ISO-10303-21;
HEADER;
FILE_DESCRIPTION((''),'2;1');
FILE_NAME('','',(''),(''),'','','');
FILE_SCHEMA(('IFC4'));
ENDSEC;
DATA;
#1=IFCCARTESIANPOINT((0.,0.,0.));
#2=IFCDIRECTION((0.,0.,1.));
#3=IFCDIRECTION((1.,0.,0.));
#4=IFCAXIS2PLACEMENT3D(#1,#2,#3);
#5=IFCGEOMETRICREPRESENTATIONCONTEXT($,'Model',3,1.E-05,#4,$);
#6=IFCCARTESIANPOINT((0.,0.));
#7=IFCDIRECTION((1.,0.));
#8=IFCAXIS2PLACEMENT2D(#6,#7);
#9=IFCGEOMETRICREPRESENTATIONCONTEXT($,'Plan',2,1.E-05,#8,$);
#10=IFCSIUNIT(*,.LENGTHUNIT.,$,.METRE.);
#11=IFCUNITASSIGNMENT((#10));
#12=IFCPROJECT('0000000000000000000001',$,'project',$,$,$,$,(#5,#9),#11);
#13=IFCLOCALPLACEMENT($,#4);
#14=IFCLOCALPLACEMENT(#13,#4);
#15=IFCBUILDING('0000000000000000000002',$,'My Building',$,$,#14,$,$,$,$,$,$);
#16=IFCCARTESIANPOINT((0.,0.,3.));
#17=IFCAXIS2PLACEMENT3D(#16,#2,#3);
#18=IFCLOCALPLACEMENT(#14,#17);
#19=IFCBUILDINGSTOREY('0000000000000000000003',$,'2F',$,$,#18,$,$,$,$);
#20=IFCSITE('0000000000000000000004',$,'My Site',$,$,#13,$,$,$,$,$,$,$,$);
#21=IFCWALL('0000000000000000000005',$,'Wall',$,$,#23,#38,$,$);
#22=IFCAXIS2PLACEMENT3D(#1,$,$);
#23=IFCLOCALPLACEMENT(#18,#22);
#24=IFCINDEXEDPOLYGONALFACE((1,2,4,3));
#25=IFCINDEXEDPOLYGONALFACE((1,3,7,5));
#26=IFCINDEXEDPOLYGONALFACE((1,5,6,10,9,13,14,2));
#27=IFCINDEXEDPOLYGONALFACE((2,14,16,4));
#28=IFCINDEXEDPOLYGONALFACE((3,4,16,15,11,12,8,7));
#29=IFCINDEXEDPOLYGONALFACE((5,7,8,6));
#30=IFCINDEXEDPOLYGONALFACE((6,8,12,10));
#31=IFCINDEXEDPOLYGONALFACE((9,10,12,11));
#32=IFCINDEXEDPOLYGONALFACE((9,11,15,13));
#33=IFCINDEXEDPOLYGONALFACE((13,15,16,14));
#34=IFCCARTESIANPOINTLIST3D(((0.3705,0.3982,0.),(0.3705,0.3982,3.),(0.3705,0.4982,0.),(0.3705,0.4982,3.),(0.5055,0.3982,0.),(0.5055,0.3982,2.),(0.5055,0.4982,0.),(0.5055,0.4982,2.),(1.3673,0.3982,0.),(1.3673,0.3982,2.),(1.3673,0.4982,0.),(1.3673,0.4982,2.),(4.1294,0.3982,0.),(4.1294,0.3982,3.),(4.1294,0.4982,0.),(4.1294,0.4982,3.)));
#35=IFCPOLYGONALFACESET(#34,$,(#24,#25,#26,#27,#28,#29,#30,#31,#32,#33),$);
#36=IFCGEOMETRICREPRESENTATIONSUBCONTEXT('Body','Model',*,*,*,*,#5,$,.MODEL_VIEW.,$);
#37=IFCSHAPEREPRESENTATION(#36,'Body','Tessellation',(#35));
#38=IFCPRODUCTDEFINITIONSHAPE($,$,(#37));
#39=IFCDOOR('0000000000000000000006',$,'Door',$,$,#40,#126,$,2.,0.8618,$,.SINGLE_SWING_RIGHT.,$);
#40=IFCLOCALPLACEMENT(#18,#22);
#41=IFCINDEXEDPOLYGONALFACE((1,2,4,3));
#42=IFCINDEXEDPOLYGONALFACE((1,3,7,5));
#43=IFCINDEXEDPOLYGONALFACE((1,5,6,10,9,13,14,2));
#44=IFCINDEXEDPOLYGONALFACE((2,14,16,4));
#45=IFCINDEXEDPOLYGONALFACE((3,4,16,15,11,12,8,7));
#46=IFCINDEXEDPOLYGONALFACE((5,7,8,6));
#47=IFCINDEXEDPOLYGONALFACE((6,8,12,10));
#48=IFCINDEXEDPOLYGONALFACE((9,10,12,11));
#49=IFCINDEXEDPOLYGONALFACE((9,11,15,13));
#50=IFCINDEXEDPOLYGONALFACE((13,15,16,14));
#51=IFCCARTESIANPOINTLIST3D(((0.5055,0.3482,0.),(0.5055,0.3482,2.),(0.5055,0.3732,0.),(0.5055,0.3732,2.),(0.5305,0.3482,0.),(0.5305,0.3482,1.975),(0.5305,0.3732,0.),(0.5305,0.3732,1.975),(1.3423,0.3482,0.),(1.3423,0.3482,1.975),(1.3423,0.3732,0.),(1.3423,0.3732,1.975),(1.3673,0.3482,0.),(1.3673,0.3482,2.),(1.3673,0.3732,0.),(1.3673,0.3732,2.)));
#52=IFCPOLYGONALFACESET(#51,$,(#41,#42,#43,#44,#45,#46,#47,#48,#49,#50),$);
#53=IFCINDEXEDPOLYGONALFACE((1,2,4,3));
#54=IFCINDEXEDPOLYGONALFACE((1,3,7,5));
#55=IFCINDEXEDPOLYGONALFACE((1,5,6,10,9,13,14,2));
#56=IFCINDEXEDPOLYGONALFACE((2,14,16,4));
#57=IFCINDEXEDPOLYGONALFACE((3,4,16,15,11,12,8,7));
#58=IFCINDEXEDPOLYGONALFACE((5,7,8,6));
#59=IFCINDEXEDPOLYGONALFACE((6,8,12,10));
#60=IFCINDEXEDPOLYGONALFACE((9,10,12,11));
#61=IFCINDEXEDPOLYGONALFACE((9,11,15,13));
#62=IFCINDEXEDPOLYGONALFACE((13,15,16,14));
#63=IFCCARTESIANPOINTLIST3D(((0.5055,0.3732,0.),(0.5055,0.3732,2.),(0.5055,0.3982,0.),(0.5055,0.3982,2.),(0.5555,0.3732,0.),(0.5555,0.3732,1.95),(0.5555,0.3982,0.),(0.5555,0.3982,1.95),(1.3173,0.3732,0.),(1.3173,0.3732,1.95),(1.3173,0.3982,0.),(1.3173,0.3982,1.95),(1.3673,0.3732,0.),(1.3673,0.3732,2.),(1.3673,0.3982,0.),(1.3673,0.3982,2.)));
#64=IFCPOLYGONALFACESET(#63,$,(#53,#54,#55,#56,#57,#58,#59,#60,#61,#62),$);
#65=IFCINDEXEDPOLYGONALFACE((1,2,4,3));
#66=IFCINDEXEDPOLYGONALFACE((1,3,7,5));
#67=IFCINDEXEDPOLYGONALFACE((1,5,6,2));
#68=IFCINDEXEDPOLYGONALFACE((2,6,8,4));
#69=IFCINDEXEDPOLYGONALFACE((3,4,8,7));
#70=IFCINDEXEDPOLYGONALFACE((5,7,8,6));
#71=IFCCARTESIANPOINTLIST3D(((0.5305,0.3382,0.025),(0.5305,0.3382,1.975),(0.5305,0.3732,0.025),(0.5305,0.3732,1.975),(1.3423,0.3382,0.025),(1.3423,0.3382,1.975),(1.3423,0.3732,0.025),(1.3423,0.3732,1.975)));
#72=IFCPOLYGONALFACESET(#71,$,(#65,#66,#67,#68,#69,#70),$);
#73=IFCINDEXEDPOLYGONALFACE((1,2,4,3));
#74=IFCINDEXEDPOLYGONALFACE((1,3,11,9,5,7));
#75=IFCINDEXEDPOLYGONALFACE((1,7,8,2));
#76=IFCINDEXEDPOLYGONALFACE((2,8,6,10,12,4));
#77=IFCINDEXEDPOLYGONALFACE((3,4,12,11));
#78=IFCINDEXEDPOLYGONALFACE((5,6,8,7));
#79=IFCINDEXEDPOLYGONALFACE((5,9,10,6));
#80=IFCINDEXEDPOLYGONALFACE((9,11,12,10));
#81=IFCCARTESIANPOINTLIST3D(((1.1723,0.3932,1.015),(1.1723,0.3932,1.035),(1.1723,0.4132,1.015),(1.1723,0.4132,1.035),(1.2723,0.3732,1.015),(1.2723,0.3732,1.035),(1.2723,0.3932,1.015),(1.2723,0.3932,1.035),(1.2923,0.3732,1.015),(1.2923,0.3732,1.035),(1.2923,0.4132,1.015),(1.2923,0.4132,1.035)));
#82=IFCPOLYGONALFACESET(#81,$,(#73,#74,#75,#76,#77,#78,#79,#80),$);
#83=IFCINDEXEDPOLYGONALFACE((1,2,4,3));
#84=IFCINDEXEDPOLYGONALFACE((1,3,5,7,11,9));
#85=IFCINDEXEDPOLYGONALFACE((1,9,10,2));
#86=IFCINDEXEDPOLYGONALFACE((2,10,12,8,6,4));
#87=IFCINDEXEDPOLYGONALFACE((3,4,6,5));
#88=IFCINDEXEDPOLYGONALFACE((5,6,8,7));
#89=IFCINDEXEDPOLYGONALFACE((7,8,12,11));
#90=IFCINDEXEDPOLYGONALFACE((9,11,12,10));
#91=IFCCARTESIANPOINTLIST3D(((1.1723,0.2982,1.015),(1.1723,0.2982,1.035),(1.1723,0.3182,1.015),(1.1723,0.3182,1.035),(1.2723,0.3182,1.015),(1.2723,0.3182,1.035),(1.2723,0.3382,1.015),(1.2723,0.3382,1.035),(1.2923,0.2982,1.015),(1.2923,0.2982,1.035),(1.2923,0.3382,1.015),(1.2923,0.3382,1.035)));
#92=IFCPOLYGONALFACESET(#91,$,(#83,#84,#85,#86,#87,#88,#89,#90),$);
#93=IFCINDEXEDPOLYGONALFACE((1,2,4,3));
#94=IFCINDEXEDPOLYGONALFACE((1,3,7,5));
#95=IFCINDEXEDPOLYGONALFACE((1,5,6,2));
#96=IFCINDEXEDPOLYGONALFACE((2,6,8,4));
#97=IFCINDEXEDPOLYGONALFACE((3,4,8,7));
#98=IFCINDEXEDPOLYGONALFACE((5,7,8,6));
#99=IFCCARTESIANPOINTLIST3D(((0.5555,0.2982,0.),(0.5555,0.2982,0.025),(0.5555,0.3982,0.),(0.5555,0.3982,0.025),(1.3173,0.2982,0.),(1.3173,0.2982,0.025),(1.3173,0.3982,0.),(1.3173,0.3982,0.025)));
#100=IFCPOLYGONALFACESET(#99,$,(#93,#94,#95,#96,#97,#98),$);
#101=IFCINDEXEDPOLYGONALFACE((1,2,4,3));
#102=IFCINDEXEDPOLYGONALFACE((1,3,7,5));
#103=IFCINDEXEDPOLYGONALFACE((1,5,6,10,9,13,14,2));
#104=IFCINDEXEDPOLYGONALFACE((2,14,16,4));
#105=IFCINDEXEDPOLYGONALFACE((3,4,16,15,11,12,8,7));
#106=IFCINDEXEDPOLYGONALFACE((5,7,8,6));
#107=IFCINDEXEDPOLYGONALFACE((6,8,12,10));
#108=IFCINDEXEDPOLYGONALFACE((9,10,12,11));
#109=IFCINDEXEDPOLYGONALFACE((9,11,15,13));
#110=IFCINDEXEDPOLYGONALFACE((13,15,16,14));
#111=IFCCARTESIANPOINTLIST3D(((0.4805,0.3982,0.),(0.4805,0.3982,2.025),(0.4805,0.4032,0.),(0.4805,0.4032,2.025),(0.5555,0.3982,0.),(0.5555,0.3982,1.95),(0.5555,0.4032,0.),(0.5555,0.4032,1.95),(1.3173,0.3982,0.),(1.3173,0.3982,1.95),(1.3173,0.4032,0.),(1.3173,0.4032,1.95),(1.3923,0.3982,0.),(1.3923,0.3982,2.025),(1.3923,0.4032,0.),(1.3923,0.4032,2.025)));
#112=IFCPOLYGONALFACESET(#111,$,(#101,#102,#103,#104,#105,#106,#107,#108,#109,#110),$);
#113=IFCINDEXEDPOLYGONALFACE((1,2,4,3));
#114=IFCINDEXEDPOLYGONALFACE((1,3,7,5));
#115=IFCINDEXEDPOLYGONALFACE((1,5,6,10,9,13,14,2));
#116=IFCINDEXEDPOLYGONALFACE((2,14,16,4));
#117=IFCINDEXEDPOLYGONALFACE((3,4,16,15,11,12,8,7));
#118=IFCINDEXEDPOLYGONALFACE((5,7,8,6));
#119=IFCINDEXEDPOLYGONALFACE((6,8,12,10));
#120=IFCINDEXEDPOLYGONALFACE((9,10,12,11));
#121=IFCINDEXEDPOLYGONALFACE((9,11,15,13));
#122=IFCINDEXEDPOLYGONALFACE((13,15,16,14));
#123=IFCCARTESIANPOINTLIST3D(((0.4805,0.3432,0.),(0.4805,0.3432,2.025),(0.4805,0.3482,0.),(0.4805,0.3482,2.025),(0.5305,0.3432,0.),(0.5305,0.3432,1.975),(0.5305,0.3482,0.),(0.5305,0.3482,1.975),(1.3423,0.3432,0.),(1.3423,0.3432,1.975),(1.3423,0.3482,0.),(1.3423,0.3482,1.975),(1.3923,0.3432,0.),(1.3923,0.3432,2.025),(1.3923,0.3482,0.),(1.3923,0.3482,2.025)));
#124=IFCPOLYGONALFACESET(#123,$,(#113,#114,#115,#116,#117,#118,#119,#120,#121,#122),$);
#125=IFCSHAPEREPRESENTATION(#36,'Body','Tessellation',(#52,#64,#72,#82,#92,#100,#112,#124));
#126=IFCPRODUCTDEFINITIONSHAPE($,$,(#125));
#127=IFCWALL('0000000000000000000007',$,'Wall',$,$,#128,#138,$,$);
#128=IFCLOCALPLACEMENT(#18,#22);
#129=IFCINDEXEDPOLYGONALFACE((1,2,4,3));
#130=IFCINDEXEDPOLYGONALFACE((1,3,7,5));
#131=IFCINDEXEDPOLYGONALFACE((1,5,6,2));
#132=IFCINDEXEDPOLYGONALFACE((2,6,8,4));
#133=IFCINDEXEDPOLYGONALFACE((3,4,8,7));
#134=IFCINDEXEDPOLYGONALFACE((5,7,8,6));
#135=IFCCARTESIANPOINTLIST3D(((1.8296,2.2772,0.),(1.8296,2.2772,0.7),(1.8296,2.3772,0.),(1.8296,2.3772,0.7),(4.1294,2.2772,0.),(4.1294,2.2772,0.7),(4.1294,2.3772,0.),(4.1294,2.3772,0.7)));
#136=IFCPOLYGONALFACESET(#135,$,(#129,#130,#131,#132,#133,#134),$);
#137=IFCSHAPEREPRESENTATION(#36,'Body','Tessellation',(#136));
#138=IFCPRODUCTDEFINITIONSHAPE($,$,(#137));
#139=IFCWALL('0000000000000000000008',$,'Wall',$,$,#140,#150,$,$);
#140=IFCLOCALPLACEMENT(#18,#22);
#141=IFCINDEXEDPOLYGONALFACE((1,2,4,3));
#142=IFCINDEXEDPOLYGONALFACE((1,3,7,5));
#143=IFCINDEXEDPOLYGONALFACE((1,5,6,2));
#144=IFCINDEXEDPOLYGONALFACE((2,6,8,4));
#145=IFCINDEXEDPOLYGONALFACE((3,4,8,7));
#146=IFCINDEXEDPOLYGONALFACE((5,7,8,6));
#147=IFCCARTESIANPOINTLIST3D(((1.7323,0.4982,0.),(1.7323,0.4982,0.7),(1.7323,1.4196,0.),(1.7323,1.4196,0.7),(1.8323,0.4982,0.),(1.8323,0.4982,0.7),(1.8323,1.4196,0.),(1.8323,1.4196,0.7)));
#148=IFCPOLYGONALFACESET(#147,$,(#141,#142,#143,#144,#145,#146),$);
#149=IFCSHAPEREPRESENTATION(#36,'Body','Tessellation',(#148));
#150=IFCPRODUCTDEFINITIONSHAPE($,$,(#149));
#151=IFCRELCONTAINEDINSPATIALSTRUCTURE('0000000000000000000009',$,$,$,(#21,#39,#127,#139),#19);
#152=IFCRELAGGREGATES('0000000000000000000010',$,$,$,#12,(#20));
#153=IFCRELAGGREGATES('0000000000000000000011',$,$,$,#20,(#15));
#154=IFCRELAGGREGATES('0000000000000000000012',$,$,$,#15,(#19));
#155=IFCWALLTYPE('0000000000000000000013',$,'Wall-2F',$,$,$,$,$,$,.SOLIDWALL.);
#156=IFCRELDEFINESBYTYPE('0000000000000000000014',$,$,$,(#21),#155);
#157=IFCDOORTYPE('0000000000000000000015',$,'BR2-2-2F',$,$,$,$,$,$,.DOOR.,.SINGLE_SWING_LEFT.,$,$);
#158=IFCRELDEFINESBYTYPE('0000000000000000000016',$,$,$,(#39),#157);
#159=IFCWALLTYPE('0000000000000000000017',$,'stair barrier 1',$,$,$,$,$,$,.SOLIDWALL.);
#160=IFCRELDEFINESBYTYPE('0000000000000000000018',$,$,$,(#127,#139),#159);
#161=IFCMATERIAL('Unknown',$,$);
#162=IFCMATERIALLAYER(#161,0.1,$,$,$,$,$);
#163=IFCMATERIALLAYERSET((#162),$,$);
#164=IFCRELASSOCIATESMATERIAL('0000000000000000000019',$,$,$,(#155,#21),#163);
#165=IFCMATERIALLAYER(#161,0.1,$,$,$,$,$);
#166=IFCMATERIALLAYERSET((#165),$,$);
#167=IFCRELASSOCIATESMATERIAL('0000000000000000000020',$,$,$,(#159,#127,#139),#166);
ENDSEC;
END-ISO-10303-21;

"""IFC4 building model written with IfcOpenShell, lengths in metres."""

from ifc_helpers import new_model, entity, si_unit, frame, origin_with_axes, origin_2d_with_axis, place, context, subcontext, project, spatial, line, indexed_curve, outline, extrude, shape, source, transform, mapped, material, layer, layer_set, layer_usage, type_object, type_shapes, element, fill, save


model = new_model("IFC4")

# Units and contexts
model_context = context("Model", 3, precision=1e-05, world=origin_with_axes())
plan_context = context("Plan", 2, precision=1e-05, world=origin_2d_with_axis())
body_context_1 = subcontext(model_context, "Body", "Model", "MODEL_VIEW")
body_context_2 = subcontext(plan_context, "Body", "Plan", "PLAN_VIEW")
ifc_project = project(units=[si_unit("LENGTHUNIT", "METRE")], contexts=[model_context, plan_context])

# Site, building, storey
site_placement = place(None, origin_with_axes())
site = spatial("IfcSite", under=ifc_project, at=site_placement, Name="My Site")
building_placement = place(site_placement, origin_with_axes())
building = spatial("IfcBuilding", under=site, at=building_placement, Name="My Building")
storey_placement = place(building_placement, frame((0.0, 0.0, 3.0), z_axis=(0.0, 0.0, 1.0), x_axis=(1.0, 0.0, 0.0)))
storey = spatial("IfcBuildingStorey", under=building, at=storey_placement, Name="2F")

# Shared definitions
ifc_material = material(Name="Unknown")

# Shared definitions
ifc_layer_1 = layer(ifc_material, 0.1)
ifc_layer_set_1 = layer_set([ifc_layer_1])
wall_type_1 = type_object("IfcWallType", Name="Wall-2F", PredefinedType="SOLIDWALL", material=ifc_layer_set_1)

# Wall, opening, door
ifc_layer_usage_1 = layer_usage(ifc_layer_set_1, "AXIS2", "NEGATIVE", 0.0)
wall_1_placement = place(storey_placement, frame((0.3705, 0.4982, 0.0), z_axis=(0.0, 0.0, 1.0), x_axis=(1.0, 0.0, 0.0)))
wall_1 = element("IfcWall", 1, at=wall_1_placement, inside=storey, type_object=wall_type_1, material=ifc_layer_usage_1, Name="Wall", context=body_context_1, shape_type="SweptSolid", body=[
    extrude(outline(indexed_curve([(0.0, -0.1), (0.0, 0.0), (3.7589, 0.0), (3.7589, -0.1)], segments=[line(1, 2, 3, 4, 1)])), origin_with_axes(), (0.0, 0.0, 1.0), 3.0),
])
shared_shape_1 = source(origin_with_axes(), body_context_1, "Body", "SweptSolid", [
    extrude(outline(indexed_curve([(0.0, 0.0), (0.8618, 0.0), (0.8618, 2.0), (0.0, 2.0)], segments=[line(1, 2, 3, 4, 1)])), frame((0.0, -0.6, 0.0), z_axis=(0.0, -1.0, 0.0), x_axis=(1.0, 0.0, 0.0)), (0.0, 0.0, -1.0), 1.2),
])
opening_1_placement = place(wall_1_placement, frame((0.9968, -0.1, 0.0), z_axis=(0.0, 0.0, 1.0), x_axis=(-1.0, 0.0, 0.0)))
opening_1 = element("IfcOpeningElement", 2, at=opening_1_placement, cuts=wall_1, PredefinedType="OPENING", context=body_context_1, shape_type="MappedRepresentation", body=[
    mapped(shared_shape_1, transform((0.0, 0.0, 0.0), x_axis=(1.0, 0.0, 0.0), y_axis=(0.0, 1.0, 0.0), z_axis=(0.0, 0.0, 1.0), scale=1.0)),
])
door_type_1 = type_object("IfcDoorType", Name="BR2-2-2F", OperationType="SINGLE_SWING_LEFT", PredefinedType="DOOR")
shared_shape_2 = source(origin_with_axes(), body_context_1, "Body", "SweptSolid", [
    extrude(outline(indexed_curve([(0.0, 0.0), (0.0, 2.0), (0.8618, 2.0), (0.8618, 0.0), (0.8368, 0.0), (0.8368, 1.975), (0.025, 1.975), (0.025, 0.0)], segments=[line(1, 2, 3, 4, 5, 6, 7, 8, 1)])), frame((0.0, 0.025, 0.0), z_axis=(0.0, -1.0, 0.0), x_axis=(1.0, 0.0, 0.0)), (0.0, 0.0, -1.0), 0.025),
    extrude(outline(indexed_curve([(0.0, 0.0), (0.0, 2.0), (0.8618, 2.0), (0.8618, 0.0), (0.8118, 0.0), (0.8118, 1.95), (0.05, 1.95), (0.05, 0.0)], segments=[line(1, 2, 3, 4, 5, 6, 7, 8, 1)])), frame((0.0, 0.0, 0.0), z_axis=(0.0, -1.0, 0.0), x_axis=(1.0, 0.0, 0.0)), (0.0, 0.0, -1.0), 0.025),
    extrude(outline(indexed_curve([(0.0, 0.0), (0.8118, 0.0), (0.8118, 0.035), (0.0, 0.035)], segments=[line(1, 2, 3, 4, 1)])), frame((0.025, 0.025, 0.025), z_axis=(0.0, 0.0, 1.0), x_axis=(1.0, 0.0, 0.0)), (0.0, 0.0, 1.0), 1.95),
    extrude(outline(indexed_curve([(0.0, 0.0), (0.0, -0.04), (0.12, -0.04), (0.12, -0.02), (0.02, -0.02), (0.02, 0.0)], segments=[line(1, 2, 3, 4, 5, 6, 1)])), frame((0.075, 0.025, 1.015), z_axis=(0.0, 0.0, 1.0), x_axis=(1.0, 0.0, 0.0)), (0.0, 0.0, 1.0), 0.02),
    extrude(outline(indexed_curve([(0.0, 0.0), (0.0, 0.04), (0.12, 0.04), (0.12, 0.02), (0.02, 0.02), (0.02, 0.0)], segments=[line(1, 2, 3, 4, 5, 6, 1)])), frame((0.075, 0.06, 1.015), z_axis=(0.0, 0.0, 1.0), x_axis=(1.0, 0.0, 0.0)), (0.0, 0.0, 1.0), 0.02),
    extrude(outline(indexed_curve([(0.0, 0.0), (0.7618, 0.0), (0.7618, 0.1), (0.0, 0.1)], segments=[line(1, 2, 3, 4, 1)])), frame((0.05, 0.0, 0.0), z_axis=(0.0, 0.0, 1.0), x_axis=(1.0, 0.0, 0.0)), (0.0, 0.0, 1.0), 0.025),
    extrude(outline(indexed_curve([(0.0, 0.0), (0.0, 2.025), (0.9118, 2.025), (0.9118, 0.0), (0.8368, 0.0), (0.8368, 1.95), (0.075, 1.95), (0.075, 0.0)], segments=[line(1, 2, 3, 4, 5, 6, 7, 8, 1)])), frame((-0.025, -0.005, 0.0), z_axis=(0.0, -1.0, 0.0), x_axis=(1.0, 0.0, 0.0)), (0.0, 0.0, -1.0), 0.005),
    extrude(outline(indexed_curve([(0.0, 0.0), (0.0, 2.025), (0.9118, 2.025), (0.9118, 0.0), (0.8618, 0.0), (0.8618, 1.975), (0.05, 1.975), (0.05, 0.0)], segments=[line(1, 2, 3, 4, 5, 6, 7, 8, 1)])), frame((-0.025, 0.05, 0.0), z_axis=(0.0, -1.0, 0.0), x_axis=(1.0, 0.0, 0.0)), (0.0, 0.0, -1.0), 0.005),
])
shared_shape_3 = source(origin_with_axes(), body_context_2, "Body", "Curve2D", [
    entity("IfcIndexedPolyCurve", entity("IfcCartesianPointList2D", [[0.0, 0.0], [0.0, 0.05], [0.025, 0.05], [0.025, 0.025], [0.05, 0.025], [0.05, 0.0]]), [entity("IfcLineIndex", [1, 2, 3, 4, 5, 6, 1])]),
    entity("IfcIndexedPolyCurve", entity("IfcCartesianPointList2D", [[0.8618, 0.0], [0.8618, 0.05], [0.8368, 0.05], [0.8368, 0.025], [0.8118, 0.025], [0.8118, 0.0]]), [entity("IfcLineIndex", [1, 2, 3, 4, 5, 6, 1])]),
    entity("IfcTrimmedCurve", entity("IfcEllipse", entity("IfcAxis2Placement2D", entity("IfcCartesianPoint", [0.8018, 0.05]), entity("IfcDirection", [1.0, 0.0])), 0.7768, 0.8118), [entity("IfcCartesianPoint", [0.8018, 0.8618])], [entity("IfcCartesianPoint", [0.025, 0.05])], True, "CARTESIAN"),
    entity("IfcIndexedPolyCurve", entity("IfcCartesianPointList2D", [[0.8368, 0.05], [0.8018, 0.05], [0.8018, 0.8618], [0.8368, 0.8618]]), [entity("IfcLineIndex", [1, 2, 3, 4, 1])]),
])
type_shapes(door_type_1, [shared_shape_2, shared_shape_3])
door_1_placement = place(opening_1_placement, frame((0.0, 0.0, 0.0), z_axis=(0.0, 0.0, 1.0), x_axis=(1.0, 0.0, 0.0)))
door_1 = element("IfcDoor", 3, at=door_1_placement, inside=storey, type_object=door_type_1, Name="Door", OperationType="SINGLE_SWING_RIGHT", OverallHeight=2.0, OverallWidth=0.8618, shapes=[
    shape(body_context_1, "Body", "MappedRepresentation", [mapped(shared_shape_2, transform((0.0, 0.0, 0.0), x_axis=(1.0, 0.0, 0.0), y_axis=(0.0, 1.0, 0.0), z_axis=(0.0, 0.0, 1.0), scale=1.0))]),
    shape(body_context_2, "Body", "MappedRepresentation", [mapped(shared_shape_3, transform((0.0, 0.0, 0.0), x_axis=(1.0, 0.0, 0.0), y_axis=(0.0, 1.0, 0.0), z_axis=(0.0, 0.0, 1.0), scale=1.0))]),
])
fill(opening_1, door_1)

# Walls
ifc_layer_2 = layer(ifc_material, 0.1)
ifc_layer_set_2 = layer_set([ifc_layer_2])
ifc_layer_usage_2 = layer_usage(ifc_layer_set_2, "AXIS2", "POSITIVE", 0.0)
wall_type_2 = type_object("IfcWallType", Name="stair barrier 1", PredefinedType="SOLIDWALL", material=ifc_layer_set_2)
wall_2_placement = place(storey_placement, frame((1.8296, 2.2772, 0.0), z_axis=(0.0, 0.0, 1.0), x_axis=(1.0, 0.0, 0.0)))
element("IfcWall", 4, at=wall_2_placement, inside=storey, type_object=wall_type_2, material=ifc_layer_usage_2, Name="Wall", context=body_context_1, shape_type="SweptSolid", body=[
    extrude(outline(indexed_curve([(0.0, 0.0), (0.0, 0.1), (2.2998, 0.1), (2.2998, 0.0)], segments=[line(1, 2, 3, 4, 1)])), origin_with_axes(), (0.0, 0.0, 1.0), 0.7),
])
ifc_layer_usage_3 = layer_usage(ifc_layer_set_2, "AXIS2", "POSITIVE", 0.0)
wall_3_placement = place(storey_placement, frame((1.7323, 1.4196, 0.0), z_axis=(0.0, 0.0, 1.0), x_axis=(0.0, -1.0, 0.0)))
element("IfcWall", 5, at=wall_3_placement, inside=storey, type_object=wall_type_2, material=ifc_layer_usage_3, Name="Wall", context=body_context_1, shape_type="SweptSolid", body=[
    extrude(outline(indexed_curve([(0.0, 0.0), (0.0, 0.1), (0.9214, 0.1), (0.9214, 0.0)], segments=[line(1, 2, 3, 4, 1)])), origin_with_axes(), (0.0, 0.0, 1.0), 0.7),
])

save(model, "model.ifc")
